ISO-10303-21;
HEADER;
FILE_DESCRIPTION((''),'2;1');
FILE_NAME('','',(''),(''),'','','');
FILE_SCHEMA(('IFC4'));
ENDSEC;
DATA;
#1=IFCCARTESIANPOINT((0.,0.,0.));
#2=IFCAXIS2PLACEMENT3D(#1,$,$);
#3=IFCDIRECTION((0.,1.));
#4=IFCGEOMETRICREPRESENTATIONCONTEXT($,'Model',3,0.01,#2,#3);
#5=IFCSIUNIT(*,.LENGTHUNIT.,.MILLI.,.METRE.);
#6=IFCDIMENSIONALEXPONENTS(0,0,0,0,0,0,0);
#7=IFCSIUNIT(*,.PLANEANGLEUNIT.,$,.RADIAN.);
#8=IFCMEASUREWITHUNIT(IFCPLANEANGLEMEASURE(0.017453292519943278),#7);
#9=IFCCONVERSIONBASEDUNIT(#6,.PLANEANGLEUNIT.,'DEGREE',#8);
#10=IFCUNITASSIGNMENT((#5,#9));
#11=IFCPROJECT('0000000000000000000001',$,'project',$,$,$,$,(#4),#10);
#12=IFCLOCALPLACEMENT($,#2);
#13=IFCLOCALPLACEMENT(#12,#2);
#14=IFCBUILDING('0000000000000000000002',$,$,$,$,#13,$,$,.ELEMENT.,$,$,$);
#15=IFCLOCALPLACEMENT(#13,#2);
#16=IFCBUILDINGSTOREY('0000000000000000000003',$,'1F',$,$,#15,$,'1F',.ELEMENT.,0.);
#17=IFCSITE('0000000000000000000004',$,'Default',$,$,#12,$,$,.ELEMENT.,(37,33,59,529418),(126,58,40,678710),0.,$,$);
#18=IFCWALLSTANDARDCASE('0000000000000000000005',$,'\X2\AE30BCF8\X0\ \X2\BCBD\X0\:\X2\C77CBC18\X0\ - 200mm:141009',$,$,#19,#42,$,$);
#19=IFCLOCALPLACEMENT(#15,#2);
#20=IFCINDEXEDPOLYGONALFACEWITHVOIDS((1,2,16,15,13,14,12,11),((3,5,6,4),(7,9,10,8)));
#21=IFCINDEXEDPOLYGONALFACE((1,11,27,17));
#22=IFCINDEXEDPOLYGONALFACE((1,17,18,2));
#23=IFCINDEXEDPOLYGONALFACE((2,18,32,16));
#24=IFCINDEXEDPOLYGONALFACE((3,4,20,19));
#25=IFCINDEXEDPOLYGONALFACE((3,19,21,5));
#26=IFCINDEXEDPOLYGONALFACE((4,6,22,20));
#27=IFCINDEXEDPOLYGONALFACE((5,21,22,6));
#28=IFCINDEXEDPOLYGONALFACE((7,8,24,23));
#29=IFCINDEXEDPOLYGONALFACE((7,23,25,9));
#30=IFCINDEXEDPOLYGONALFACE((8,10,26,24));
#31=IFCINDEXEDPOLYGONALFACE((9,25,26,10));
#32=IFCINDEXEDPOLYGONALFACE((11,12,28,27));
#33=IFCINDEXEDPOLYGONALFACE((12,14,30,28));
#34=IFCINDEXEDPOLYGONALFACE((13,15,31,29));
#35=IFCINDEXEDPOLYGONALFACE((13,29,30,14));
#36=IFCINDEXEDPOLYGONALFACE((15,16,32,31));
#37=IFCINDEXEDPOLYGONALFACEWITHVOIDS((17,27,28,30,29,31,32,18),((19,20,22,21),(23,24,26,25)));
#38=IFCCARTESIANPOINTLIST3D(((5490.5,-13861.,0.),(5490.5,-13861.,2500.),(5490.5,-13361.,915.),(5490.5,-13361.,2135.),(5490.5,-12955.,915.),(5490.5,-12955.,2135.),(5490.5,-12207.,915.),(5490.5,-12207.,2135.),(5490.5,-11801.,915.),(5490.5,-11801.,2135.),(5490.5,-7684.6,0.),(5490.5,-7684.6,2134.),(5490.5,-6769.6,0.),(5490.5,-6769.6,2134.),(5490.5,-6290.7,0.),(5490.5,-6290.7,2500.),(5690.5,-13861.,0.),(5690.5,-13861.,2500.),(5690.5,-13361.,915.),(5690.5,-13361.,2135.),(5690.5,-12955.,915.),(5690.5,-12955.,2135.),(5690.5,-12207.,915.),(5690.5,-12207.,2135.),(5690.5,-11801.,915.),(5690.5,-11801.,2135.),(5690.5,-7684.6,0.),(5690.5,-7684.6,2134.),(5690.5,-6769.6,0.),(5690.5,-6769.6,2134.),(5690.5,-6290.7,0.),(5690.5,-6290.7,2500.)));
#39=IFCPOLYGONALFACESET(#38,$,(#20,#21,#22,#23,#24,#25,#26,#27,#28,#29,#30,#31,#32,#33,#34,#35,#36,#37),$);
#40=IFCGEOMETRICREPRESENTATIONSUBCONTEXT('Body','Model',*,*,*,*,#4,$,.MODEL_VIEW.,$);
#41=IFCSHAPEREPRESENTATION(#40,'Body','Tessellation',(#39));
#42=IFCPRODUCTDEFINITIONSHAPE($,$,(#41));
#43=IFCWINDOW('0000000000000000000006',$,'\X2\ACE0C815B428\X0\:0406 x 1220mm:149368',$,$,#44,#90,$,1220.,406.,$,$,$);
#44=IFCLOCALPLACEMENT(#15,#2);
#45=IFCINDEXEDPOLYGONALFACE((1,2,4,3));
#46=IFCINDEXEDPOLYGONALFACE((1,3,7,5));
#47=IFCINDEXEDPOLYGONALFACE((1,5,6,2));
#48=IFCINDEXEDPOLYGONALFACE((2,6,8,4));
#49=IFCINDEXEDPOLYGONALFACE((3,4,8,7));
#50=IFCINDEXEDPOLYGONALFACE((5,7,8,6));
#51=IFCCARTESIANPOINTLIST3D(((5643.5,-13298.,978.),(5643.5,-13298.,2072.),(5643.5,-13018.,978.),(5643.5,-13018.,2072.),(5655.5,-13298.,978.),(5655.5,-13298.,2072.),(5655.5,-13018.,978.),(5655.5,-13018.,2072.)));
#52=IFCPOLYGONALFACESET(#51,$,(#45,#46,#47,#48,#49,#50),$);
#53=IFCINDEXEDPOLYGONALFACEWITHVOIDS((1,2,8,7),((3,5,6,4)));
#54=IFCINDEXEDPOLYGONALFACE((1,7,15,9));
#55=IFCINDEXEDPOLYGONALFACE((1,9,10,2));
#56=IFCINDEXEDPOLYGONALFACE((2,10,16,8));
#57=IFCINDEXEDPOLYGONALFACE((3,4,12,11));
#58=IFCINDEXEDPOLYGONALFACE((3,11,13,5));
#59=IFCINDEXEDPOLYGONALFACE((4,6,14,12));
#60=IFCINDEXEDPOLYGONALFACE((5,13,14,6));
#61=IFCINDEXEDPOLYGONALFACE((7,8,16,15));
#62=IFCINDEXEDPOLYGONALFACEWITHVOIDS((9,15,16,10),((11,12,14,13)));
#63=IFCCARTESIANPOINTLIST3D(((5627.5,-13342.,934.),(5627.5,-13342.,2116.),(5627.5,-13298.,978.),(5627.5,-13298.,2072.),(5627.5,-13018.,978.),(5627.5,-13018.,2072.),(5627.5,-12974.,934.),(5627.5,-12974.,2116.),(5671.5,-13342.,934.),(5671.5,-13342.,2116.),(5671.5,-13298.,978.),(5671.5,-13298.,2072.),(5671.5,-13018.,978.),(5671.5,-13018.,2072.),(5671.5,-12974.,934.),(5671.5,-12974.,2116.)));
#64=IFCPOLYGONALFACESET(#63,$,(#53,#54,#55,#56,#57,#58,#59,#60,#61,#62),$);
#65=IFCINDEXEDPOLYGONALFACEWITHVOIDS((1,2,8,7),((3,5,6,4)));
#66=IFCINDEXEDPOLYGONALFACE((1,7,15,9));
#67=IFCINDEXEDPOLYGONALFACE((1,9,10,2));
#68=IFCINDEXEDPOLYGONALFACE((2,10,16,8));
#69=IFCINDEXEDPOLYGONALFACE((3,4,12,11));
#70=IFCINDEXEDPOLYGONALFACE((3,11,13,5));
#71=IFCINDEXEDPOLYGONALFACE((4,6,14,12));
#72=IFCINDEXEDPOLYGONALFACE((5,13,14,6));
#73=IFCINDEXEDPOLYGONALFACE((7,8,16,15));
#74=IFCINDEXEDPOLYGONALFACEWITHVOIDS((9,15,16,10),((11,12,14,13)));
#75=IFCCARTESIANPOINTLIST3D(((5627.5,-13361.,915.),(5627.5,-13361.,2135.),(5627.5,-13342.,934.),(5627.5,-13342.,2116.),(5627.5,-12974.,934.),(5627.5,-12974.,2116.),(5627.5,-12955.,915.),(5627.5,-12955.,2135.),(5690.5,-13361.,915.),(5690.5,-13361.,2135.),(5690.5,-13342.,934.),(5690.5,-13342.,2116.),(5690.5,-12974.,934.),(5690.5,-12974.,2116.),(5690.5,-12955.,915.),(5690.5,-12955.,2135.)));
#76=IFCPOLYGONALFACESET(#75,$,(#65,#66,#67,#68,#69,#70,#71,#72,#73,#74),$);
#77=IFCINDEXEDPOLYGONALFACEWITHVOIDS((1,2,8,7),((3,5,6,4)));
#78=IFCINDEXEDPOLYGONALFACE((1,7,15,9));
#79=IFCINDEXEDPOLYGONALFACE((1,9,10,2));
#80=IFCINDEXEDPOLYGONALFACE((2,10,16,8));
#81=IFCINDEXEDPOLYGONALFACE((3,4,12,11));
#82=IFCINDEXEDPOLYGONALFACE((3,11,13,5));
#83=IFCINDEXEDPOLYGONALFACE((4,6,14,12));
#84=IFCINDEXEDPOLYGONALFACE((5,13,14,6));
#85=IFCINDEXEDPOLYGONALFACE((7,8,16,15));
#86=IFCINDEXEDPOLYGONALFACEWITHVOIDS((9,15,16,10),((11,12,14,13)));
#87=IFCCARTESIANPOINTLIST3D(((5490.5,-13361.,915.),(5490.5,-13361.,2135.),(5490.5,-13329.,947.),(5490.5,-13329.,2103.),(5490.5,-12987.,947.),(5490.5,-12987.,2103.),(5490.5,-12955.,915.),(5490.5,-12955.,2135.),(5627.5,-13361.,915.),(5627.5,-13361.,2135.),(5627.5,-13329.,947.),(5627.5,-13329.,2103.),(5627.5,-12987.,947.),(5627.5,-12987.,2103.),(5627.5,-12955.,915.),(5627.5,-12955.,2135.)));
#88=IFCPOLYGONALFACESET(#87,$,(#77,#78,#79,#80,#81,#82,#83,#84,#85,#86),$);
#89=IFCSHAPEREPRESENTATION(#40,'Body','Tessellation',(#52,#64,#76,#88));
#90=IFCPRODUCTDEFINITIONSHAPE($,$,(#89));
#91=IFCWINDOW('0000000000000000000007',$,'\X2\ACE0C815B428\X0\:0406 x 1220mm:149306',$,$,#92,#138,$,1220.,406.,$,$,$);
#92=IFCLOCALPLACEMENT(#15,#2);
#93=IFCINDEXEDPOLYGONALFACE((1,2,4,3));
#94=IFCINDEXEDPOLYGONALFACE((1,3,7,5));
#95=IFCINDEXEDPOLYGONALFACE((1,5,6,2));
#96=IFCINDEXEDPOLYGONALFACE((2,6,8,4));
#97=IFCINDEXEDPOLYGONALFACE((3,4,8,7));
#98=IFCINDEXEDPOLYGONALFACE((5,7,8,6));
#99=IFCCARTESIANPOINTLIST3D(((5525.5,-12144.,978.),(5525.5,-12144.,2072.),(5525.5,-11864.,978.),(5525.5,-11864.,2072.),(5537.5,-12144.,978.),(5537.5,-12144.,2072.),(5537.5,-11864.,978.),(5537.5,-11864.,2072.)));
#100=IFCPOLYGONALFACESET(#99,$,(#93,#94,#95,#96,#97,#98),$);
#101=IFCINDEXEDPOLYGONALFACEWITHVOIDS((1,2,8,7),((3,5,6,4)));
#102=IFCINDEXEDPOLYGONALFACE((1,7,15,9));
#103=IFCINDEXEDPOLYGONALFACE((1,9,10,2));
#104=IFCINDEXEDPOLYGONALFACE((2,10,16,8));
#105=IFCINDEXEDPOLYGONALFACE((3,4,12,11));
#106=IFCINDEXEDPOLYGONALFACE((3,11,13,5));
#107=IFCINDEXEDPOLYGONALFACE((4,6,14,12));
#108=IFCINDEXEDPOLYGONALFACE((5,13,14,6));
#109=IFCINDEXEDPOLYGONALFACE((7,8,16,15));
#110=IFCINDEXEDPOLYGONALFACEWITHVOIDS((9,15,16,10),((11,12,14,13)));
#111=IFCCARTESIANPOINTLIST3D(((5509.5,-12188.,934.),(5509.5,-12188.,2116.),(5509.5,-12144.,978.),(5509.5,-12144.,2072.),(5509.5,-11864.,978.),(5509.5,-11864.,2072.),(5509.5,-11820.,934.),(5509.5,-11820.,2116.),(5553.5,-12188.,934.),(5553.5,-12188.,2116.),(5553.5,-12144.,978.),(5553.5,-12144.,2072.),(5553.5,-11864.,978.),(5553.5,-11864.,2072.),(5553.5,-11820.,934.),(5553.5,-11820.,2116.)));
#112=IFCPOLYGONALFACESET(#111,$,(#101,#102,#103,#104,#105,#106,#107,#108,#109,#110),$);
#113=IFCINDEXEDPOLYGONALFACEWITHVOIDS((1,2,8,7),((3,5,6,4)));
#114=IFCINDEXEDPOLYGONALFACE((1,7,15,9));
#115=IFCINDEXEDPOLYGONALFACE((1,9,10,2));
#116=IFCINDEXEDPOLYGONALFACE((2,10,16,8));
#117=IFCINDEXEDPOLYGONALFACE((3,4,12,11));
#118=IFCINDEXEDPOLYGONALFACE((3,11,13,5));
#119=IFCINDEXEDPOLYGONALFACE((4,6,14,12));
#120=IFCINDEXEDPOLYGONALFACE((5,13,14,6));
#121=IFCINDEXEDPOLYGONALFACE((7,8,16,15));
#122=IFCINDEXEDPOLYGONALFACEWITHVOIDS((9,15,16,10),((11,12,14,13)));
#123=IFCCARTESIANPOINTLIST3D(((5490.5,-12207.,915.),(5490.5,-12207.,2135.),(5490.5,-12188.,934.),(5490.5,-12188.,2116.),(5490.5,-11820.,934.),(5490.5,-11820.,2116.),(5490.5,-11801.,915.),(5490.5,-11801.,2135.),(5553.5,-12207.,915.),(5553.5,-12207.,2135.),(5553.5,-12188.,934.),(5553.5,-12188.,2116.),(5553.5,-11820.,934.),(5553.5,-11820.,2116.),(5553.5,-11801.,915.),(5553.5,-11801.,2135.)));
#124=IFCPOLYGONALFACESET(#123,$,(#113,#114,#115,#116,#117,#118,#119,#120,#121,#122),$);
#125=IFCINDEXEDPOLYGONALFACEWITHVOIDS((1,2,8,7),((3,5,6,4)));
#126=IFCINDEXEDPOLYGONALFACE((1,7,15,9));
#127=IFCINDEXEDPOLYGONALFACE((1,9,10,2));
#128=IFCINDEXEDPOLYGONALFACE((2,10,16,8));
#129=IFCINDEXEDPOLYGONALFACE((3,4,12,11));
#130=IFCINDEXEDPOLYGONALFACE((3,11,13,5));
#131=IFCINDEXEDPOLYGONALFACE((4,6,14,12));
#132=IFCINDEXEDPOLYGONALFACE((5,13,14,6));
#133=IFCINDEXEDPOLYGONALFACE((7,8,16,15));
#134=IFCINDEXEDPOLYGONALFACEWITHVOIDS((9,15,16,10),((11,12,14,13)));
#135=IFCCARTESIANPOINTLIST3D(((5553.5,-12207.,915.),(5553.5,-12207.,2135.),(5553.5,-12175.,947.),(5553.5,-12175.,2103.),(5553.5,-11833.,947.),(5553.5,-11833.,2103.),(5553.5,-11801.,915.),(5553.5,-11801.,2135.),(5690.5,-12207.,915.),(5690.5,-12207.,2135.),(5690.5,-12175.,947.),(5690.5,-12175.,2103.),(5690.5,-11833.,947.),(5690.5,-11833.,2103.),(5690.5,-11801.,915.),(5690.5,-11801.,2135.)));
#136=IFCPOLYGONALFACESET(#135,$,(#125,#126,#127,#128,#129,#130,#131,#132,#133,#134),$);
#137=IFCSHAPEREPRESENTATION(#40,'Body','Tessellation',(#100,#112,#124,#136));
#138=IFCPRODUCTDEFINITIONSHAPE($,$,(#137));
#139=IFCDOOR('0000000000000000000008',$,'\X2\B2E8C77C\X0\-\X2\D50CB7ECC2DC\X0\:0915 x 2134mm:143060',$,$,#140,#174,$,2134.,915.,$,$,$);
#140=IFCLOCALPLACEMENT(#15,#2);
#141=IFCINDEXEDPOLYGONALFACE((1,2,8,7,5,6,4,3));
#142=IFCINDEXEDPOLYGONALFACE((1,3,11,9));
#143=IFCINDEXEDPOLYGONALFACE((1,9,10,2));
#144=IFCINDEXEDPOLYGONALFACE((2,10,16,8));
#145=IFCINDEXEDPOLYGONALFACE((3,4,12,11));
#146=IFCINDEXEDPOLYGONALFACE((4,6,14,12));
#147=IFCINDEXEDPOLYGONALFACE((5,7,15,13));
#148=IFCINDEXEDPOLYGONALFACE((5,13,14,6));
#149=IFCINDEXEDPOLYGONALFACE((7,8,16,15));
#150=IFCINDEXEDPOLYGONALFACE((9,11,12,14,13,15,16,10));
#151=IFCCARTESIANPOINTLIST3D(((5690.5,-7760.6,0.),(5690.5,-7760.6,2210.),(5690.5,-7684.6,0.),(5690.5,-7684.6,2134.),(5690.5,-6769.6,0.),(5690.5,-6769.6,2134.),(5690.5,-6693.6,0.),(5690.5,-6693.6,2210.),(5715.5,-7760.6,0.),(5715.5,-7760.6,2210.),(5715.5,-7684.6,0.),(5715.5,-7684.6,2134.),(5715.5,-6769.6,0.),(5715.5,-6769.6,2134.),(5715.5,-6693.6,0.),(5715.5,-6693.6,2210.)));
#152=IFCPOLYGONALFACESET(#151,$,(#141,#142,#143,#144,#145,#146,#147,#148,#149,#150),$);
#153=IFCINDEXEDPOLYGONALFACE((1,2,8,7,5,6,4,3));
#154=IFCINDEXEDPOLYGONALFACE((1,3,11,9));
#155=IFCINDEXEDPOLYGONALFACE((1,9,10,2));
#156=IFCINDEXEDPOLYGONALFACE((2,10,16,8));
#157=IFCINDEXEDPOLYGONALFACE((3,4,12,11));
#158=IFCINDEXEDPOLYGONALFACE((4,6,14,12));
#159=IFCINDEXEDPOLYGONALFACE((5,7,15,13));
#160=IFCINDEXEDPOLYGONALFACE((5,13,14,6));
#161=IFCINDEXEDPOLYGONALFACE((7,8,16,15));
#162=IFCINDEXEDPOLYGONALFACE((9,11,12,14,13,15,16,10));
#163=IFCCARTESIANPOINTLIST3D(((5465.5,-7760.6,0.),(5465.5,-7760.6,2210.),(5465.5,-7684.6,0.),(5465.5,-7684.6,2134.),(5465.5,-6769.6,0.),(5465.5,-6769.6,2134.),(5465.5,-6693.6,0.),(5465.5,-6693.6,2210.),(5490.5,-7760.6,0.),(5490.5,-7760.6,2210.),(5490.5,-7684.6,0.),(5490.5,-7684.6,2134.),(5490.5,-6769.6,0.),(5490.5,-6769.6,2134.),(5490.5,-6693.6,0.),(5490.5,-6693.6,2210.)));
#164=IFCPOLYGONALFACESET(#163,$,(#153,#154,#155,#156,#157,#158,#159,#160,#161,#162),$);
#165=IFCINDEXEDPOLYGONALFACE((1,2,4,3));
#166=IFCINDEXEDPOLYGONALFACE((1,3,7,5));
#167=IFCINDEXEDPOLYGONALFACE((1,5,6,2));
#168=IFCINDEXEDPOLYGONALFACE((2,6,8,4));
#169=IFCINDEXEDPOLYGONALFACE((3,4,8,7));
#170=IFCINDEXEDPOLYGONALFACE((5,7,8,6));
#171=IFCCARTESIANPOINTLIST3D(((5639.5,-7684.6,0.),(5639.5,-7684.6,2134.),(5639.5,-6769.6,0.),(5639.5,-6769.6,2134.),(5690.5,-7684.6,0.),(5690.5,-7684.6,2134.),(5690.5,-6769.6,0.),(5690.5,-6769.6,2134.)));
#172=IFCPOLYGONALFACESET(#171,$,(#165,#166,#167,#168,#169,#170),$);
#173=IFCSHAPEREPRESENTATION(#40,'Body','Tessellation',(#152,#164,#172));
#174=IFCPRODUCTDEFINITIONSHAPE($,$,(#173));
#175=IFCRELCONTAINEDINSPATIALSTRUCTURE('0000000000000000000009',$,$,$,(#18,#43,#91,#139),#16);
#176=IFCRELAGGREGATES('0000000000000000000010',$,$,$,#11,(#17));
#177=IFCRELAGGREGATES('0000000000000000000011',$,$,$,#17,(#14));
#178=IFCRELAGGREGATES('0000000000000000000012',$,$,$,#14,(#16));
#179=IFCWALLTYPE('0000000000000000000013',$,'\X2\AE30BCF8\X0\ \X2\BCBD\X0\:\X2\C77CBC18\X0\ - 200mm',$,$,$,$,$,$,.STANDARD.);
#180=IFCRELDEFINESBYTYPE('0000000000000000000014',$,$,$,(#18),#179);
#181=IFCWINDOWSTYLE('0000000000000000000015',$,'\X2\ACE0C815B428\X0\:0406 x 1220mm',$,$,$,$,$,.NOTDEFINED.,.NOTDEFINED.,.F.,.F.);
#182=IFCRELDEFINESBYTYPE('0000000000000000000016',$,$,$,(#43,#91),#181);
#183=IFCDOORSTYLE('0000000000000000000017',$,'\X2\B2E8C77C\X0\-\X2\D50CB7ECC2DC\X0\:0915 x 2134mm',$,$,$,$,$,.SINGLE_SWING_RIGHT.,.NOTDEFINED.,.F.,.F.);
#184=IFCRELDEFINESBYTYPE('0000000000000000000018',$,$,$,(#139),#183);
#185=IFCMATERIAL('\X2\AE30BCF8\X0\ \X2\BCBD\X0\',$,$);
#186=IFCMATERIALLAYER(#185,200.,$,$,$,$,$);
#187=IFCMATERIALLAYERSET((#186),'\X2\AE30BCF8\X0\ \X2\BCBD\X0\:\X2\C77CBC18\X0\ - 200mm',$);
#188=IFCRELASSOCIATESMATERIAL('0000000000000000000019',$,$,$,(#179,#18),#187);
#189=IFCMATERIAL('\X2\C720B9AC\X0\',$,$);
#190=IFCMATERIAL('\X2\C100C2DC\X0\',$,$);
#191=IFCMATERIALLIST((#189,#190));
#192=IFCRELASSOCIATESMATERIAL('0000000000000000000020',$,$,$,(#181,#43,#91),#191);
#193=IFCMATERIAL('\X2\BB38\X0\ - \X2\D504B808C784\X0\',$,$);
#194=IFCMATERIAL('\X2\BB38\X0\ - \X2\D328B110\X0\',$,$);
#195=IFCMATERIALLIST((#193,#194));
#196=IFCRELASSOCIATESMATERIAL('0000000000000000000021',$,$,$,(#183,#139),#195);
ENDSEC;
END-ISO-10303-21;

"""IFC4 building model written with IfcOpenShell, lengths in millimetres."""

from ifc_helpers import new_model, entity, si_unit, converted_unit, direction, frame, frame_2d, origin, place, context, subcontext, project, spatial, polyline, rectangle, outline, extrude, source, transform, mapped, material, material_list, layer, layer_set, layer_usage, type_object, type_shapes, element, fill, save


model = new_model("IFC4")

# Units and contexts
model_context = context("Model", 3, precision=0.01, world=origin(), true_north=direction((0.0, 1.0)))
body_context = subcontext(model_context, "Body", "Model", "MODEL_VIEW")
ifc_project = project(units=[si_unit("LENGTHUNIT", "METRE", prefix="MILLI"), converted_unit("PLANEANGLEUNIT", "DEGREE", entity("IfcPlaneAngleMeasure", 0.017453292519943278), si_unit("PLANEANGLEUNIT", "RADIAN"), dimensions=[0, 0, 0, 0, 0, 0, 0])], contexts=[model_context])

# Site, building, storey
site_placement = place(None, origin())
site = spatial("IfcSite", under=ifc_project, at=site_placement, Name="Default", CompositionType="ELEMENT", RefLatitude=(37, 33, 59, 529418), RefLongitude=(126, 58, 40, 678710), RefElevation=0.0)
building_placement = place(site_placement, origin())
building = spatial("IfcBuilding", under=site, at=building_placement, CompositionType="ELEMENT")
storey_placement = place(building_placement, origin())
storey = spatial("IfcBuildingStorey", under=building, at=storey_placement, Name="1F", LongName="1F", CompositionType="ELEMENT", Elevation=0.0)

# Shared definitions
ifc_material_1 = material(Name="기본 벽")
ifc_layer = layer(ifc_material_1, 200.0)
ifc_layer_set = layer_set([ifc_layer], Name="기본 벽:일반 - 200mm")
wall_type = type_object("IfcWallType", Name="기본 벽:일반 - 200mm", PredefinedType="STANDARD", material=ifc_layer_set)
ifc_material_2 = material(Name="유리")
ifc_material_3 = material(Name="섀시")
ifc_material_list_1 = material_list([ifc_material_2, ifc_material_3])
window_style_1 = type_object("IfcWindowStyle", Name="고정됨:0406 x 1220mm", ConstructionType="NOTDEFINED", OperationType="NOTDEFINED", ParameterTakesPrecedence=False, Sizeable=False, material=ifc_material_list_1)
shared_shape_1 = source(origin(), body_context, "Body", "SweptSolid", [
    extrude(rectangle(XDim=12.0, YDim=280.0, at=frame_2d((0.0, 0.0), x_axis=(1.0, 0.0))), frame((203.0, 159.0, 63.0), z_axis=(0.0, 0.0, 1.0), x_axis=(0.0, -1.0, 0.0)), (0.0, 0.0, 1.0), 1094.0),
    extrude(outline(polyline([(-184.0, -591.0), (184.0, -591.0), (184.0, 591.0), (-184.0, 591.0), (-184.0, -591.0)]), holes=[polyline([(-140.0, -547.0), (-140.0, 547.0), (140.0, 547.0), (140.0, -547.0), (-140.0, -547.0)])]), frame((203.0, 137.0, 610.0), z_axis=(0.0, 1.0, 0.0), x_axis=(1.0, 0.0, 0.0)), (0.0, 0.0, 1.0), 44.0),
    extrude(outline(polyline([(-203.0, -610.0), (203.0, -610.0), (203.0, 610.0), (-203.0, 610.0), (-203.0, -610.0)]), holes=[polyline([(-184.0, -591.0), (-184.0, 591.0), (184.0, 591.0), (184.0, -591.0), (-184.0, -591.0)])]), frame((203.0, 137.0, 610.0), z_axis=(0.0, 1.0, 0.0), x_axis=(1.0, 0.0, 0.0)), (0.0, 0.0, 1.0), 63.0),
    extrude(outline(polyline([(-203.0, -610.0), (203.0, -610.0), (203.0, 610.0), (-203.0, 610.0), (-203.0, -610.0)]), holes=[polyline([(-171.0, -578.0), (-171.0, 578.0), (171.0, 578.0), (171.0, -578.0), (-171.0, -578.0)])]), frame((203.0, 0.0, 610.0), z_axis=(0.0, 1.0, 0.0), x_axis=(1.0, 0.0, 0.0)), (0.0, 0.0, 1.0), 137.0),
])
type_shapes(window_style_1, [shared_shape_1])

# Shared definitions
ifc_material_4 = material(Name="문 - 프레임")
ifc_material_5 = material(Name="문 - 패널")
ifc_material_list_2 = material_list([ifc_material_4, ifc_material_5])
door_style_1 = type_object("IfcDoorStyle", Name="단일-플러시:0915 x 2134mm", ConstructionType="NOTDEFINED", OperationType="SINGLE_SWING_RIGHT", ParameterTakesPrecedence=False, Sizeable=False, material=ifc_material_list_2)
shared_shape_2 = source(origin(), body_context, "Body", "SweptSolid", [
    extrude(outline(polyline([(-533.5, -1124.0), (533.5, -1124.0), (533.5, 1086.0), (457.5, 1086.0), (457.5, -1048.0), (-457.5, -1048.0), (-457.5, 1086.0), (-533.5, 1086.0), (-533.5, -1124.0)])), frame((457.5, 200.0, 1086.0), z_axis=(0.0, 1.0, 0.0), x_axis=(1.0, 0.0, 0.0)), (0.0, 0.0, 1.0), 25.0),
    extrude(outline(polyline([(-1124.0, -533.5), (1086.0, -533.5), (1086.0, -457.5), (-1048.0, -457.5), (-1048.0, 457.5), (1086.0, 457.5), (1086.0, 533.5), (-1124.0, 533.5), (-1124.0, -533.5)])), frame((457.5, -25.0, 1086.0), z_axis=(0.0, 1.0, 0.0), x_axis=(0.0, 0.0, -1.0)), (0.0, 0.0, 1.0), 25.0),
    extrude(rectangle(XDim=51.0, YDim=915.0, at=frame_2d((0.0, 0.0), x_axis=(1.0, 0.0))), frame((457.5, 174.5, 0.0), z_axis=(0.0, 0.0, 1.0), x_axis=(0.0, 1.0, 0.0)), (0.0, 0.0, 1.0), 2134.0),
])
type_shapes(door_style_1, [shared_shape_2])

# Wall, openings, windows, door
ifc_layer_usage_1 = layer_usage(ifc_layer_set, "AXIS2", "NEGATIVE", 100.0)
wall_1_placement = place(storey_placement, frame((5590.5, -6290.7, 0.0), z_axis=(0.0, 0.0, 1.0), x_axis=(0.0, -1.0, 0.0)))
wall_1 = element("IfcWallStandardCase", 1, at=wall_1_placement, inside=storey, type_object=wall_type, material=ifc_layer_usage_1, Name="기본 벽:일반 - 200mm:141009", context=body_context, shape_type="SweptSolid", body=[
    extrude(rectangle(XDim=7570.2, YDim=200.0, at=frame_2d((3785.1, 0.0), x_axis=(-1.0, 0.0))), origin(), (0.0, 0.0, 1.0), 2500.0),
])
opening_1_placement = place(wall_1_placement, frame((478.9, -100.0, 0.0)))
opening_1 = element("IfcOpeningElement", 2, at=opening_1_placement, cuts=wall_1, ObjectType="Opening", context=body_context, shape_type="SweptSolid", body=[
    extrude(rectangle(XDim=915.0, YDim=2134.0, at=frame_2d((1067.0, 457.5), x_axis=(0.0, 1.0))), frame((0.0, 0.0, 0.0), z_axis=(0.0, 1.0, 0.0), x_axis=(0.0, 0.0, 1.0)), (0.0, 0.0, 1.0), 200.0),
])
opening_2_placement = place(wall_1_placement, frame((6664.2, -100.0, 915.0)))
opening_2 = element("IfcOpeningElement", 3, at=opening_2_placement, cuts=wall_1, ObjectType="Opening", context=body_context, shape_type="SweptSolid", body=[
    extrude(rectangle(XDim=1220.0, YDim=406.0, at=frame_2d((610.0, 203.0), x_axis=(1.0, 0.0))), frame((0.0, 0.0, 0.0), z_axis=(0.0, 1.0, 0.0), x_axis=(0.0, 0.0, 1.0)), (0.0, 0.0, 1.0), 200.0),
])
opening_3_placement = place(wall_1_placement, frame((5916.2, 100.0, 915.0)))
opening_3 = element("IfcOpeningElement", 4, at=opening_3_placement, cuts=wall_1, ObjectType="Opening", context=body_context, shape_type="SweptSolid", body=[
    extrude(rectangle(XDim=1220.0, YDim=406.0, at=frame_2d((610.0, 203.0), x_axis=(1.0, 0.0))), frame((0.0, 0.0, 0.0), z_axis=(0.0, -1.0, 0.0), x_axis=(0.0, 0.0, 1.0)), (0.0, 0.0, 1.0), 200.0),
])
window_1_placement = place(opening_2_placement, origin())
window_1 = element("IfcWindow", 5, at=window_1_placement, inside=storey, type_object=window_style_1, material=ifc_material_list_1, Name="고정됨:0406 x 1220mm:149368", OverallHeight=1220.0, OverallWidth=406.0, context=body_context, shape_type="MappedRepresentation", body=[
    mapped(shared_shape_1, transform((0.0, 0.0, 0.0), scale=1.0)),
])
fill(opening_2, window_1)
window_2_placement = place(opening_3_placement, frame((0.0, 0.0, 0.0), z_axis=(0.0, 0.0, 1.0), x_axis=(-1.0, 0.0, 0.0)))
window_2 = element("IfcWindow", 6, at=window_2_placement, inside=storey, type_object=window_style_1, material=ifc_material_list_1, Name="고정됨:0406 x 1220mm:149306", OverallHeight=1220.0, OverallWidth=406.0, context=body_context, shape_type="MappedRepresentation", body=[
    mapped(shared_shape_1, transform((0.0, 0.0, 0.0), scale=1.0)),
])
fill(opening_3, window_2)
door_1_placement = place(opening_1_placement, origin())
door_1 = element("IfcDoor", 7, at=door_1_placement, inside=storey, type_object=door_style_1, material=ifc_material_list_2, Name="단일-플러시:0915 x 2134mm:143060", OverallHeight=2134.0, OverallWidth=915.0, context=body_context, shape_type="MappedRepresentation", body=[
    mapped(shared_shape_2, transform((0.0, 0.0, 0.0), scale=1.0)),
])
fill(opening_1, door_1)

save(model, "model.ifc")
